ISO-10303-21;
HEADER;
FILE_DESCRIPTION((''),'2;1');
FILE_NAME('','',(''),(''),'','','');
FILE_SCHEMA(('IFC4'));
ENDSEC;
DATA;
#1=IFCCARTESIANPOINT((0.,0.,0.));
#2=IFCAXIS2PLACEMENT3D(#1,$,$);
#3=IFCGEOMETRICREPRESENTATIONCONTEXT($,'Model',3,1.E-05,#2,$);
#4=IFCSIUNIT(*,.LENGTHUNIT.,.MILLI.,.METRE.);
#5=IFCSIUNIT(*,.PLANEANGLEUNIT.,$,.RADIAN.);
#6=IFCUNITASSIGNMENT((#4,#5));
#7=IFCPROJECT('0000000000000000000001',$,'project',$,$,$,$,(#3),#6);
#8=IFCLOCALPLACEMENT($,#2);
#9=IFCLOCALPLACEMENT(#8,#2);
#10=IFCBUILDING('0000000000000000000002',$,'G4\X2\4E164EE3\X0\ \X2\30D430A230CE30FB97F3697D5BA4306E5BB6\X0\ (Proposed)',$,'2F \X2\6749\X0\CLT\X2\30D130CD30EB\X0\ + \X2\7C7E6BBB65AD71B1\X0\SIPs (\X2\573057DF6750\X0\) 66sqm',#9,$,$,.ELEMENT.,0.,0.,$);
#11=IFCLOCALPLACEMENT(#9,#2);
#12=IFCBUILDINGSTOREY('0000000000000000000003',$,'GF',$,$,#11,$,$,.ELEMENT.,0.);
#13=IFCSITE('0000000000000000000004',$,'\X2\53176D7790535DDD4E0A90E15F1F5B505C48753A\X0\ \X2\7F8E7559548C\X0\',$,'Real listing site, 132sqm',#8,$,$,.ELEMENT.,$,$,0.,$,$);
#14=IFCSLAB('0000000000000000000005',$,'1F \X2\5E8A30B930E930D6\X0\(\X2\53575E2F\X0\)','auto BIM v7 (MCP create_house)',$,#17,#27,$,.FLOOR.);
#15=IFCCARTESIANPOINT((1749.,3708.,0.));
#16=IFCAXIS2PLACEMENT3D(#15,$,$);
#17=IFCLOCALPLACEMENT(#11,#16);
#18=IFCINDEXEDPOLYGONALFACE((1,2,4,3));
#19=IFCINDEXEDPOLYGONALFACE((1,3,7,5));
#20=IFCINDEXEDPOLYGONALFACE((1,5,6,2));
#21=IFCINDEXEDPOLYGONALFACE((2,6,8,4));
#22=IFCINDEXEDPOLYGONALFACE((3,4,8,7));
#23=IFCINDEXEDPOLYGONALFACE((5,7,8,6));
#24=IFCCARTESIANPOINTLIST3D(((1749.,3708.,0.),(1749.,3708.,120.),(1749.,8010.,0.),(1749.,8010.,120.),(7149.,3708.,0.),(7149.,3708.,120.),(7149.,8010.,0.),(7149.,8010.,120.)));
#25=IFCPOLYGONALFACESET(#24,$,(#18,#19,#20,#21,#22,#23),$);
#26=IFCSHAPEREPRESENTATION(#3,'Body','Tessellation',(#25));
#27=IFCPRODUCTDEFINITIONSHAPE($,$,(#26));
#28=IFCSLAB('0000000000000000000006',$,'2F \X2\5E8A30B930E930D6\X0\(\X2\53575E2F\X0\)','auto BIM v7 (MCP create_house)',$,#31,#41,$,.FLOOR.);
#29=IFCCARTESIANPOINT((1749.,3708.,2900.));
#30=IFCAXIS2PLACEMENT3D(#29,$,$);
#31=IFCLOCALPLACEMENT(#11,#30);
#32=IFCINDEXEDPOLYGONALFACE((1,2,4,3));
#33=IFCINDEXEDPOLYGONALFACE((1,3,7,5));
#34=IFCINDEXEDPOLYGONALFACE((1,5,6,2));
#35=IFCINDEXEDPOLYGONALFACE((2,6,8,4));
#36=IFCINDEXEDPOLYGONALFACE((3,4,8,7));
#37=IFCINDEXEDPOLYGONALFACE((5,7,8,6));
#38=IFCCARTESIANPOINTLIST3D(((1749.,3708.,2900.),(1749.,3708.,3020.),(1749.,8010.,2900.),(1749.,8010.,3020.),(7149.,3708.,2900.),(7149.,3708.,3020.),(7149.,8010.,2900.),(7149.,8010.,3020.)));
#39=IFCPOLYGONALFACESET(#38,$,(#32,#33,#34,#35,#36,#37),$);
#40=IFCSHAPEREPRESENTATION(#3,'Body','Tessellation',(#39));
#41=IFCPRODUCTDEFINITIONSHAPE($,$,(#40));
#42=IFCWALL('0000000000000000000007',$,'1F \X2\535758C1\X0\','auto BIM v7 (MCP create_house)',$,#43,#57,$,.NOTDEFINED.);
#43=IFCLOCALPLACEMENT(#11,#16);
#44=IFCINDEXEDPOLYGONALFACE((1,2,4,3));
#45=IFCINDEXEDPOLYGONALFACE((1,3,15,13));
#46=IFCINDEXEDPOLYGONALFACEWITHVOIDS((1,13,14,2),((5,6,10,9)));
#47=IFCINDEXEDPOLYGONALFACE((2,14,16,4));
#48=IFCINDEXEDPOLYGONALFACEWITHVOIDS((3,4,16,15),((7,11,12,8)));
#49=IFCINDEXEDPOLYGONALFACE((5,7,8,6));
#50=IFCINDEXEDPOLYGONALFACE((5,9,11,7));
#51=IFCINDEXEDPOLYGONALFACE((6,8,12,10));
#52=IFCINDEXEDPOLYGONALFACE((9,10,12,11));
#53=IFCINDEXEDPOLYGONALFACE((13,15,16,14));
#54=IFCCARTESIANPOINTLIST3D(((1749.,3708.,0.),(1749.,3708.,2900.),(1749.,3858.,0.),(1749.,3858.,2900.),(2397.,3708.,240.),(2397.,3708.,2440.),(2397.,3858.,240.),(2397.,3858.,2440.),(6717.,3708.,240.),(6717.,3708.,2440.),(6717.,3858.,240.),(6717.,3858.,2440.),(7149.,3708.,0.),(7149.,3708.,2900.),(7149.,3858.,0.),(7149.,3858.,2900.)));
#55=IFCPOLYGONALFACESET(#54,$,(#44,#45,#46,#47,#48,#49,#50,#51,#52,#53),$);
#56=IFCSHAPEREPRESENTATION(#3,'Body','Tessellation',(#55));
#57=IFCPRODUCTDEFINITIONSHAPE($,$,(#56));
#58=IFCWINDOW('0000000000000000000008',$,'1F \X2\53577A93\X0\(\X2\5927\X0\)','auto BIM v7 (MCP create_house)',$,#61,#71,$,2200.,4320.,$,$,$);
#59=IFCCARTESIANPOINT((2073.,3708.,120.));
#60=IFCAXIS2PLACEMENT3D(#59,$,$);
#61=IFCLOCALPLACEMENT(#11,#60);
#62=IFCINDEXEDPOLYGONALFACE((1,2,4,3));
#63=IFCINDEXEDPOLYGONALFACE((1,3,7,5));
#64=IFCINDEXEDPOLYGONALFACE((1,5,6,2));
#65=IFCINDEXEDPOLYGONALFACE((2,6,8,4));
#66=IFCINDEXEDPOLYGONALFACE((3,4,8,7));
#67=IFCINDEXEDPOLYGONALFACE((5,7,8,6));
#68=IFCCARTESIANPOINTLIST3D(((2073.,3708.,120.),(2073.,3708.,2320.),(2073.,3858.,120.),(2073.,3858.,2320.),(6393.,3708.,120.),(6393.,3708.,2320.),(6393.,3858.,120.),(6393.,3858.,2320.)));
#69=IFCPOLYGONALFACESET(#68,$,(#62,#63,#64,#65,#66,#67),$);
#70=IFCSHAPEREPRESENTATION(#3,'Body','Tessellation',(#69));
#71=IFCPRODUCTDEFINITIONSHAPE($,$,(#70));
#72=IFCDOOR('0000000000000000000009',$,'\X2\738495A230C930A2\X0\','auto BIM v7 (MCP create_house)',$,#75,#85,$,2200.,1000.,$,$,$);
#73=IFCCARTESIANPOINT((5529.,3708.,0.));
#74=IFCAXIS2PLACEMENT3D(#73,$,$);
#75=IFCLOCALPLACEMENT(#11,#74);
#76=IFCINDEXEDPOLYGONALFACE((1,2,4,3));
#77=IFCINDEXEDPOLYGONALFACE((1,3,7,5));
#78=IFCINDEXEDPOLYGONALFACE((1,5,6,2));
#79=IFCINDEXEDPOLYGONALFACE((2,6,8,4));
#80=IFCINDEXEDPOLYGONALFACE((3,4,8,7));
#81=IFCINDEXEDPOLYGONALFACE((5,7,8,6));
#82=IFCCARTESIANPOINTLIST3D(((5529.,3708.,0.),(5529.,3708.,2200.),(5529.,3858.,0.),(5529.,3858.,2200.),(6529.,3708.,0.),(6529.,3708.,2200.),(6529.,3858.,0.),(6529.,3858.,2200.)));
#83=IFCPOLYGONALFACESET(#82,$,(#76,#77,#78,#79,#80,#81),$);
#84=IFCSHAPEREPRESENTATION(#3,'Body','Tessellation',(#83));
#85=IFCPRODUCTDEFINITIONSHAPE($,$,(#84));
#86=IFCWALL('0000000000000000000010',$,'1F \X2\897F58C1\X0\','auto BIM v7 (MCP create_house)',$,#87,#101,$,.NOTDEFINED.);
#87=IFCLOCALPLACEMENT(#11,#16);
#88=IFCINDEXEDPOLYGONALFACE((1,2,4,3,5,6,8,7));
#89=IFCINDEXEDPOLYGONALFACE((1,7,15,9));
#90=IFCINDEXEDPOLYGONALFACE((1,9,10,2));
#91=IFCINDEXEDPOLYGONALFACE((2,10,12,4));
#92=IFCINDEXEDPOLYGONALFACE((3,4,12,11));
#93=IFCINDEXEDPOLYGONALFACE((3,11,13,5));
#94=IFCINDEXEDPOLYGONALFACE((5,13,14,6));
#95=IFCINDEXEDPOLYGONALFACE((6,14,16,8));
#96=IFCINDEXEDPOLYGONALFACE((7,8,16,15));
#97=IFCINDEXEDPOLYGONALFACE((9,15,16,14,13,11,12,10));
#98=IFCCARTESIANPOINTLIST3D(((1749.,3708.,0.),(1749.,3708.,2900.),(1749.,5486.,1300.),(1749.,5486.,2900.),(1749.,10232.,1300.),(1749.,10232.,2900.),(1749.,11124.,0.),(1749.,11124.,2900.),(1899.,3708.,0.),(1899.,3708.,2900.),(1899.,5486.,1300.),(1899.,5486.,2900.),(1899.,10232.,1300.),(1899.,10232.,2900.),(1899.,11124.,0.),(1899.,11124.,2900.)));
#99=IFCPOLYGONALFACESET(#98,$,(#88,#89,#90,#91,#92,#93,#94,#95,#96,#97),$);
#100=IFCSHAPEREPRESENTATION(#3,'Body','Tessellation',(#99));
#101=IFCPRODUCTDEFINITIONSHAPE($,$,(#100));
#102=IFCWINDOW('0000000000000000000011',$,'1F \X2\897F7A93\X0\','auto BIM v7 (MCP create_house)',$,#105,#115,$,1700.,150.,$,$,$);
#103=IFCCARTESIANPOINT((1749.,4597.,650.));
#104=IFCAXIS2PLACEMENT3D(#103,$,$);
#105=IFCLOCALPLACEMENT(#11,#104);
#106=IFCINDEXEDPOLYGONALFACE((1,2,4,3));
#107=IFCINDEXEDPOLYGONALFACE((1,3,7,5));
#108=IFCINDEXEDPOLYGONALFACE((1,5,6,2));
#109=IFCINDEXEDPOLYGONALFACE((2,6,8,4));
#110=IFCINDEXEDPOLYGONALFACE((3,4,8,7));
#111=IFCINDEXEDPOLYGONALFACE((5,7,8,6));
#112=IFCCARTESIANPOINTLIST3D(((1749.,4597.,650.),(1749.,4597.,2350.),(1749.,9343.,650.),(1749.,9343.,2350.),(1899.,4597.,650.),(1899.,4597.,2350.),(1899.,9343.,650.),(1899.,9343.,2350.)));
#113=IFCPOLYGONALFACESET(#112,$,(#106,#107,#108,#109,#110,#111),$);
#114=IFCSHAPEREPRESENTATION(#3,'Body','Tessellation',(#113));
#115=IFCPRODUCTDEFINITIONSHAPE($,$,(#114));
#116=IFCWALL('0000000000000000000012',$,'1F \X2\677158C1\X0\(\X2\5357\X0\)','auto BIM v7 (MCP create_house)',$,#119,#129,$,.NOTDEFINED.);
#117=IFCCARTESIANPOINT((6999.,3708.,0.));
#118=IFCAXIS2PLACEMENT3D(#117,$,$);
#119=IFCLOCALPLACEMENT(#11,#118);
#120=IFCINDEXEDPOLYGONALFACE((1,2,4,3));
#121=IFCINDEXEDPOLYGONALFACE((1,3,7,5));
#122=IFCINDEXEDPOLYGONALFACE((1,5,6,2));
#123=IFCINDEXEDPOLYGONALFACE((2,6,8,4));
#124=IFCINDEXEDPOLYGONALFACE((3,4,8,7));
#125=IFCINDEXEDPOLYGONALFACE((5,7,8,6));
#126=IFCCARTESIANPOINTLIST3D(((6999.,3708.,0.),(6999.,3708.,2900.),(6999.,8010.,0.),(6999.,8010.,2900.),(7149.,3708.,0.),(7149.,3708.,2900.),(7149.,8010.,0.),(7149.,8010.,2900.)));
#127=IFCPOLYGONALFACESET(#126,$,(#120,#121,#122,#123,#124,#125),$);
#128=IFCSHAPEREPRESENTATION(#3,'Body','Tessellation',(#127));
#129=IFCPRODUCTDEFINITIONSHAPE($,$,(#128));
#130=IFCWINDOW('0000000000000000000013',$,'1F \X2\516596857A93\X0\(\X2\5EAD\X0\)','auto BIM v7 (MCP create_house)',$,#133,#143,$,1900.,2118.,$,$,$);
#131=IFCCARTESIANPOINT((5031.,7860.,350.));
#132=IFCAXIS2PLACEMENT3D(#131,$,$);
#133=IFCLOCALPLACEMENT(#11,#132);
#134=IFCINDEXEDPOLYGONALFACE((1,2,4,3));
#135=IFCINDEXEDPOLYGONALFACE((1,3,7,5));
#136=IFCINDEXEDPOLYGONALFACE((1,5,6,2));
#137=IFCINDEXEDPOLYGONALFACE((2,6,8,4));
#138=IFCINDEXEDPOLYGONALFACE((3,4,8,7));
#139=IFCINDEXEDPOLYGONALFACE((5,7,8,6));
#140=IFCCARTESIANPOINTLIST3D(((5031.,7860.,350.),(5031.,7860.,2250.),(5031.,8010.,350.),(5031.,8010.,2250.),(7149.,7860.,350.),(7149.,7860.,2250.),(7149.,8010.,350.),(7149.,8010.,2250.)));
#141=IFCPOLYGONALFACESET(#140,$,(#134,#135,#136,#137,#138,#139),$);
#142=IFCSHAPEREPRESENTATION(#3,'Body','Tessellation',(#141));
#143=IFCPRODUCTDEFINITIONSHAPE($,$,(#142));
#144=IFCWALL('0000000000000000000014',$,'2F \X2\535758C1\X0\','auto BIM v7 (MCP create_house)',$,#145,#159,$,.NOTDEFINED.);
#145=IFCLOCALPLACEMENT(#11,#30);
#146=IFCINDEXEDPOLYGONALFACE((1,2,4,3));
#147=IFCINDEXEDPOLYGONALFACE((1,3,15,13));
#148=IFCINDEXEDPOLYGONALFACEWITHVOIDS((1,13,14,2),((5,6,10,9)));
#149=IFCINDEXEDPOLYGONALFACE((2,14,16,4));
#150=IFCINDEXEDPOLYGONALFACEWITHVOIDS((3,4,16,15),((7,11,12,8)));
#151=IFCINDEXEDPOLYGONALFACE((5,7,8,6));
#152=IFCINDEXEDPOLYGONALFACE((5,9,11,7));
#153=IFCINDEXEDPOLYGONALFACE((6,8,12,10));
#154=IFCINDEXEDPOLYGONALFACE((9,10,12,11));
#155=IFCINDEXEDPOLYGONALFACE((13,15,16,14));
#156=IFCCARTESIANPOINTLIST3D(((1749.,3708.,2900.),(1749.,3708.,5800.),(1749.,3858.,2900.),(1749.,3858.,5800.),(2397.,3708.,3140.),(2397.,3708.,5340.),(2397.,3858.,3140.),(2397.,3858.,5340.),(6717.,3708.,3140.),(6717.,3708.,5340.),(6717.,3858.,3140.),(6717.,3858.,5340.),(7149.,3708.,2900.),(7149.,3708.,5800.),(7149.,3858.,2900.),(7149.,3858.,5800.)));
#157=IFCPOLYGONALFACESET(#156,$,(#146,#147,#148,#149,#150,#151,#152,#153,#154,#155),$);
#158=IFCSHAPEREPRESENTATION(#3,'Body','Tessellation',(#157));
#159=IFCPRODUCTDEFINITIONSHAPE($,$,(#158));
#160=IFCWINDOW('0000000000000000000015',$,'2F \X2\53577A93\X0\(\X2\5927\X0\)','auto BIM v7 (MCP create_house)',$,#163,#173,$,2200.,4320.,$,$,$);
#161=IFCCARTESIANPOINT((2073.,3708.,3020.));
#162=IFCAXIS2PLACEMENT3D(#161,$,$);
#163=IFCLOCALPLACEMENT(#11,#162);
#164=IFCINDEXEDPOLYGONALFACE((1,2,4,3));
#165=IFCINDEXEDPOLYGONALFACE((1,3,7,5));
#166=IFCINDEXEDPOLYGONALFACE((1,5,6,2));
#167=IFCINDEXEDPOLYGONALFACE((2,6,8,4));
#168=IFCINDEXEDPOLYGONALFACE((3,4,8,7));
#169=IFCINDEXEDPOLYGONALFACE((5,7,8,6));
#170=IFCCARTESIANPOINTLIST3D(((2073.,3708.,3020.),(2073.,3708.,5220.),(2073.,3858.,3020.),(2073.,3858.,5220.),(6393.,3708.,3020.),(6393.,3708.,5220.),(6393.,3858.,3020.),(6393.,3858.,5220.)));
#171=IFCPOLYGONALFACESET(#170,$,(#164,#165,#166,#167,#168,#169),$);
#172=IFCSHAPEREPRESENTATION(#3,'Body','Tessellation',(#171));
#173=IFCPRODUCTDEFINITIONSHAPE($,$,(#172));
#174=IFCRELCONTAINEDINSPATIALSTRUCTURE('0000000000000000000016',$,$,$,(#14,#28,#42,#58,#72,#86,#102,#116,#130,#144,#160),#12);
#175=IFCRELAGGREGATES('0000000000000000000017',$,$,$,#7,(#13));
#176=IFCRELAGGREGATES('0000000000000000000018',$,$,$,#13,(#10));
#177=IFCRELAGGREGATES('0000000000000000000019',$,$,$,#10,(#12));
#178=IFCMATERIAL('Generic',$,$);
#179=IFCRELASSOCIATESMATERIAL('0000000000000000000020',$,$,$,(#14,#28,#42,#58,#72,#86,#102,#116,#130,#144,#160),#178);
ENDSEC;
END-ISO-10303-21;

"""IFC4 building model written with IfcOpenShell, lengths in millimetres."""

from ifc_helpers import new_model, si_unit, frame, frame_2d, origin, place, context, project, spatial, rectangle, extrude, material, element, fill, save


model = new_model("IFC4")

# Units and contexts
model_context = context("Model", 3, precision=1e-05, world=origin())
ifc_project = project(units=[si_unit("LENGTHUNIT", "METRE", prefix="MILLI"), si_unit("PLANEANGLEUNIT", "RADIAN")], contexts=[model_context])

# Site, building, storey
site_placement = place(None, origin())
site = spatial("IfcSite", under=ifc_project, at=site_placement, Name="北海道川上郡弟子屈町 美留和", ObjectType="Real listing site, 132sqm", CompositionType="ELEMENT", RefElevation=0.0)
building_placement = place(site_placement, origin())
building = spatial("IfcBuilding", under=site, at=building_placement, Name="G4世代 ピアノ・音楽室の家 (Proposed)", ObjectType="2F 杉CLTパネル + 籾殻断熱SIPs (地域材) 66sqm", CompositionType="ELEMENT", ElevationOfRefHeight=0.0, ElevationOfTerrain=0.0)
storey_placement = place(building_placement, origin())
storey = spatial("IfcBuildingStorey", under=building, at=storey_placement, Name="GF", CompositionType="ELEMENT", Elevation=0.0)

# Slabs
ifc_material = material(Name="Generic")
slab_1_placement = place(storey_placement, frame((1749.0, 3708.0, 0.0)))
element("IfcSlab", 1, at=slab_1_placement, inside=storey, material=ifc_material, Name="1F 床スラブ(南帯)", Description="auto BIM v7 (MCP create_house)", PredefinedType="FLOOR", context=model_context, shape_type="SweptSolid", body=[
    extrude(rectangle(XDim=5400.0, YDim=4302.0, at=frame_2d((2700.0, 2151.0))), frame((1749.0, 3708.0, 0.0)), (0.0, 0.0, 1.0), 120.0),
])
slab_2_placement = place(storey_placement, frame((1749.0, 3708.0, 2900.0)))
element("IfcSlab", 2, at=slab_2_placement, inside=storey, material=ifc_material, Name="2F 床スラブ(南帯)", Description="auto BIM v7 (MCP create_house)", PredefinedType="FLOOR", context=model_context, shape_type="SweptSolid", body=[
    extrude(rectangle(XDim=5400.0, YDim=4302.0, at=frame_2d((2700.0, 2151.0))), frame((1749.0, 3708.0, 2900.0)), (0.0, 0.0, 1.0), 120.0),
])

# Wall, openings, window, door
wall_1_placement = place(storey_placement, frame((1749.0, 3708.0, 0.0)))
wall_1 = element("IfcWall", 3, at=wall_1_placement, inside=storey, material=ifc_material, Name="1F 南壁", Description="auto BIM v7 (MCP create_house)", PredefinedType="NOTDEFINED", context=model_context, shape_type="SweptSolid", body=[
    extrude(rectangle(XDim=5400.0, YDim=150.0, at=frame_2d((2700.0, 75.0))), frame((1749.0, 3708.0, 0.0)), (0.0, 0.0, 1.0), 2900.0),
])
opening_1_placement = place(storey_placement, frame((2073.0, 3708.0, 120.0)))
opening_1 = element("IfcOpeningElement", 4, at=opening_1_placement, cuts=wall_1, PredefinedType="NOTDEFINED", context=model_context, shape_type="SweptSolid", body=[
    extrude(rectangle(XDim=4320.0, YDim=150.0, at=frame_2d((2160.0, 75.0))), frame((2073.0, 3708.0, 120.0)), (0.0, 0.0, 1.0), 2200.0),
])
opening_2_placement = place(storey_placement, frame((5529.0, 3708.0, 0.0)))
opening_2 = element("IfcOpeningElement", 5, at=opening_2_placement, cuts=wall_1, PredefinedType="NOTDEFINED", context=model_context, shape_type="SweptSolid", body=[
    extrude(rectangle(XDim=1000.0, YDim=150.0, at=frame_2d((500.0, 75.0))), frame((5529.0, 3708.0, 0.0)), (0.0, 0.0, 1.0), 2200.0),
])
window_1_placement = place(storey_placement, frame((2073.0, 3708.0, 120.0)))
window_1 = element("IfcWindow", 6, at=window_1_placement, inside=storey, material=ifc_material, Name="1F 南窓(大)", Description="auto BIM v7 (MCP create_house)", OverallHeight=2200.0, OverallWidth=4320.0, context=model_context, shape_type="SweptSolid", body=[
    extrude(rectangle(XDim=4320.0, YDim=150.0, at=frame_2d((2160.0, 75.0))), frame((2073.0, 3708.0, 120.0)), (0.0, 0.0, 1.0), 2200.0),
])
fill(opening_1, window_1)
door_placement = place(storey_placement, frame((5529.0, 3708.0, 0.0)))
door = element("IfcDoor", 7, at=door_placement, inside=storey, material=ifc_material, Name="玄関ドア", Description="auto BIM v7 (MCP create_house)", OverallHeight=2200.0, OverallWidth=1000.0, context=model_context, shape_type="SweptSolid", body=[
    extrude(rectangle(XDim=1000.0, YDim=150.0, at=frame_2d((500.0, 75.0))), frame((5529.0, 3708.0, 0.0)), (0.0, 0.0, 1.0), 2200.0),
])
fill(opening_2, door)

# Walls, openings, windows
wall_2_placement = place(storey_placement, frame((1749.0, 3708.0, 0.0)))
wall_2 = element("IfcWall", 8, at=wall_2_placement, inside=storey, material=ifc_material, Name="1F 西壁", Description="auto BIM v7 (MCP create_house)", PredefinedType="NOTDEFINED", context=model_context, shape_type="SweptSolid", body=[
    extrude(rectangle(XDim=150.0, YDim=7416.0, at=frame_2d((75.0, 3708.0))), frame((1749.0, 3708.0, 0.0)), (0.0, 0.0, 1.0), 2900.0),
])
opening_3_placement = place(storey_placement, frame((1749.0, 4597.0, 650.0)))
opening_3 = element("IfcOpeningElement", 9, at=opening_3_placement, cuts=wall_2, PredefinedType="NOTDEFINED", context=model_context, shape_type="SweptSolid", body=[
    extrude(rectangle(XDim=150.0, YDim=4746.0, at=frame_2d((75.0, 2373.0))), frame((1749.0, 4597.0, 650.0)), (0.0, 0.0, 1.0), 1700.0),
])
window_2_placement = place(storey_placement, frame((1749.0, 4597.0, 650.0)))
window_2 = element("IfcWindow", 10, at=window_2_placement, inside=storey, material=ifc_material, Name="1F 西窓", Description="auto BIM v7 (MCP create_house)", OverallHeight=1700.0, OverallWidth=150.0, context=model_context, shape_type="SweptSolid", body=[
    extrude(rectangle(XDim=150.0, YDim=4746.0, at=frame_2d((75.0, 2373.0))), frame((1749.0, 4597.0, 650.0)), (0.0, 0.0, 1.0), 1700.0),
])
fill(opening_3, window_2)
wall_3_placement = place(storey_placement, frame((6999.0, 3708.0, 0.0)))
wall_3 = element("IfcWall", 11, at=wall_3_placement, inside=storey, material=ifc_material, Name="1F 東壁(南)", Description="auto BIM v7 (MCP create_house)", PredefinedType="NOTDEFINED", context=model_context, shape_type="SweptSolid", body=[
    extrude(rectangle(XDim=150.0, YDim=4302.0, at=frame_2d((75.0, 2151.0))), frame((6999.0, 3708.0, 0.0)), (0.0, 0.0, 1.0), 2900.0),
])
opening_4_placement = place(storey_placement, frame((5031.0, 7860.0, 350.0)))
opening_4 = element("IfcOpeningElement", 12, at=opening_4_placement, cuts=wall_3, PredefinedType="NOTDEFINED", context=model_context, shape_type="SweptSolid", body=[
    extrude(rectangle(XDim=2118.0, YDim=150.0, at=frame_2d((1059.0, 75.0))), frame((5031.0, 7860.0, 350.0)), (0.0, 0.0, 1.0), 1900.0),
])
window_3_placement = place(storey_placement, frame((5031.0, 7860.0, 350.0)))
window_3 = element("IfcWindow", 13, at=window_3_placement, inside=storey, material=ifc_material, Name="1F 入隅窓(庭)", Description="auto BIM v7 (MCP create_house)", OverallHeight=1900.0, OverallWidth=2118.0, context=model_context, shape_type="SweptSolid", body=[
    extrude(rectangle(XDim=2118.0, YDim=150.0, at=frame_2d((1059.0, 75.0))), frame((5031.0, 7860.0, 350.0)), (0.0, 0.0, 1.0), 1900.0),
])
fill(opening_4, window_3)

# Wall, opening, window
wall_4_placement = place(storey_placement, frame((1749.0, 3708.0, 2900.0)))
wall_4 = element("IfcWall", 14, at=wall_4_placement, inside=storey, material=ifc_material, Name="2F 南壁", Description="auto BIM v7 (MCP create_house)", PredefinedType="NOTDEFINED", context=model_context, shape_type="SweptSolid", body=[
    extrude(rectangle(XDim=5400.0, YDim=150.0, at=frame_2d((2700.0, 75.0))), frame((1749.0, 3708.0, 2900.0)), (0.0, 0.0, 1.0), 2900.0),
])
opening_5_placement = place(storey_placement, frame((2073.0, 3708.0, 3020.0)))
opening_5 = element("IfcOpeningElement", 15, at=opening_5_placement, cuts=wall_4, PredefinedType="NOTDEFINED", context=model_context, shape_type="SweptSolid", body=[
    extrude(rectangle(XDim=4320.0, YDim=150.0, at=frame_2d((2160.0, 75.0))), frame((2073.0, 3708.0, 3020.0)), (0.0, 0.0, 1.0), 2200.0),
])
window_4_placement = place(storey_placement, frame((2073.0, 3708.0, 3020.0)))
window_4 = element("IfcWindow", 16, at=window_4_placement, inside=storey, material=ifc_material, Name="2F 南窓(大)", Description="auto BIM v7 (MCP create_house)", OverallHeight=2200.0, OverallWidth=4320.0, context=model_context, shape_type="SweptSolid", body=[
    extrude(rectangle(XDim=4320.0, YDim=150.0, at=frame_2d((2160.0, 75.0))), frame((2073.0, 3708.0, 3020.0)), (0.0, 0.0, 1.0), 2200.0),
])
fill(opening_5, window_4)

save(model, "model.ifc")
